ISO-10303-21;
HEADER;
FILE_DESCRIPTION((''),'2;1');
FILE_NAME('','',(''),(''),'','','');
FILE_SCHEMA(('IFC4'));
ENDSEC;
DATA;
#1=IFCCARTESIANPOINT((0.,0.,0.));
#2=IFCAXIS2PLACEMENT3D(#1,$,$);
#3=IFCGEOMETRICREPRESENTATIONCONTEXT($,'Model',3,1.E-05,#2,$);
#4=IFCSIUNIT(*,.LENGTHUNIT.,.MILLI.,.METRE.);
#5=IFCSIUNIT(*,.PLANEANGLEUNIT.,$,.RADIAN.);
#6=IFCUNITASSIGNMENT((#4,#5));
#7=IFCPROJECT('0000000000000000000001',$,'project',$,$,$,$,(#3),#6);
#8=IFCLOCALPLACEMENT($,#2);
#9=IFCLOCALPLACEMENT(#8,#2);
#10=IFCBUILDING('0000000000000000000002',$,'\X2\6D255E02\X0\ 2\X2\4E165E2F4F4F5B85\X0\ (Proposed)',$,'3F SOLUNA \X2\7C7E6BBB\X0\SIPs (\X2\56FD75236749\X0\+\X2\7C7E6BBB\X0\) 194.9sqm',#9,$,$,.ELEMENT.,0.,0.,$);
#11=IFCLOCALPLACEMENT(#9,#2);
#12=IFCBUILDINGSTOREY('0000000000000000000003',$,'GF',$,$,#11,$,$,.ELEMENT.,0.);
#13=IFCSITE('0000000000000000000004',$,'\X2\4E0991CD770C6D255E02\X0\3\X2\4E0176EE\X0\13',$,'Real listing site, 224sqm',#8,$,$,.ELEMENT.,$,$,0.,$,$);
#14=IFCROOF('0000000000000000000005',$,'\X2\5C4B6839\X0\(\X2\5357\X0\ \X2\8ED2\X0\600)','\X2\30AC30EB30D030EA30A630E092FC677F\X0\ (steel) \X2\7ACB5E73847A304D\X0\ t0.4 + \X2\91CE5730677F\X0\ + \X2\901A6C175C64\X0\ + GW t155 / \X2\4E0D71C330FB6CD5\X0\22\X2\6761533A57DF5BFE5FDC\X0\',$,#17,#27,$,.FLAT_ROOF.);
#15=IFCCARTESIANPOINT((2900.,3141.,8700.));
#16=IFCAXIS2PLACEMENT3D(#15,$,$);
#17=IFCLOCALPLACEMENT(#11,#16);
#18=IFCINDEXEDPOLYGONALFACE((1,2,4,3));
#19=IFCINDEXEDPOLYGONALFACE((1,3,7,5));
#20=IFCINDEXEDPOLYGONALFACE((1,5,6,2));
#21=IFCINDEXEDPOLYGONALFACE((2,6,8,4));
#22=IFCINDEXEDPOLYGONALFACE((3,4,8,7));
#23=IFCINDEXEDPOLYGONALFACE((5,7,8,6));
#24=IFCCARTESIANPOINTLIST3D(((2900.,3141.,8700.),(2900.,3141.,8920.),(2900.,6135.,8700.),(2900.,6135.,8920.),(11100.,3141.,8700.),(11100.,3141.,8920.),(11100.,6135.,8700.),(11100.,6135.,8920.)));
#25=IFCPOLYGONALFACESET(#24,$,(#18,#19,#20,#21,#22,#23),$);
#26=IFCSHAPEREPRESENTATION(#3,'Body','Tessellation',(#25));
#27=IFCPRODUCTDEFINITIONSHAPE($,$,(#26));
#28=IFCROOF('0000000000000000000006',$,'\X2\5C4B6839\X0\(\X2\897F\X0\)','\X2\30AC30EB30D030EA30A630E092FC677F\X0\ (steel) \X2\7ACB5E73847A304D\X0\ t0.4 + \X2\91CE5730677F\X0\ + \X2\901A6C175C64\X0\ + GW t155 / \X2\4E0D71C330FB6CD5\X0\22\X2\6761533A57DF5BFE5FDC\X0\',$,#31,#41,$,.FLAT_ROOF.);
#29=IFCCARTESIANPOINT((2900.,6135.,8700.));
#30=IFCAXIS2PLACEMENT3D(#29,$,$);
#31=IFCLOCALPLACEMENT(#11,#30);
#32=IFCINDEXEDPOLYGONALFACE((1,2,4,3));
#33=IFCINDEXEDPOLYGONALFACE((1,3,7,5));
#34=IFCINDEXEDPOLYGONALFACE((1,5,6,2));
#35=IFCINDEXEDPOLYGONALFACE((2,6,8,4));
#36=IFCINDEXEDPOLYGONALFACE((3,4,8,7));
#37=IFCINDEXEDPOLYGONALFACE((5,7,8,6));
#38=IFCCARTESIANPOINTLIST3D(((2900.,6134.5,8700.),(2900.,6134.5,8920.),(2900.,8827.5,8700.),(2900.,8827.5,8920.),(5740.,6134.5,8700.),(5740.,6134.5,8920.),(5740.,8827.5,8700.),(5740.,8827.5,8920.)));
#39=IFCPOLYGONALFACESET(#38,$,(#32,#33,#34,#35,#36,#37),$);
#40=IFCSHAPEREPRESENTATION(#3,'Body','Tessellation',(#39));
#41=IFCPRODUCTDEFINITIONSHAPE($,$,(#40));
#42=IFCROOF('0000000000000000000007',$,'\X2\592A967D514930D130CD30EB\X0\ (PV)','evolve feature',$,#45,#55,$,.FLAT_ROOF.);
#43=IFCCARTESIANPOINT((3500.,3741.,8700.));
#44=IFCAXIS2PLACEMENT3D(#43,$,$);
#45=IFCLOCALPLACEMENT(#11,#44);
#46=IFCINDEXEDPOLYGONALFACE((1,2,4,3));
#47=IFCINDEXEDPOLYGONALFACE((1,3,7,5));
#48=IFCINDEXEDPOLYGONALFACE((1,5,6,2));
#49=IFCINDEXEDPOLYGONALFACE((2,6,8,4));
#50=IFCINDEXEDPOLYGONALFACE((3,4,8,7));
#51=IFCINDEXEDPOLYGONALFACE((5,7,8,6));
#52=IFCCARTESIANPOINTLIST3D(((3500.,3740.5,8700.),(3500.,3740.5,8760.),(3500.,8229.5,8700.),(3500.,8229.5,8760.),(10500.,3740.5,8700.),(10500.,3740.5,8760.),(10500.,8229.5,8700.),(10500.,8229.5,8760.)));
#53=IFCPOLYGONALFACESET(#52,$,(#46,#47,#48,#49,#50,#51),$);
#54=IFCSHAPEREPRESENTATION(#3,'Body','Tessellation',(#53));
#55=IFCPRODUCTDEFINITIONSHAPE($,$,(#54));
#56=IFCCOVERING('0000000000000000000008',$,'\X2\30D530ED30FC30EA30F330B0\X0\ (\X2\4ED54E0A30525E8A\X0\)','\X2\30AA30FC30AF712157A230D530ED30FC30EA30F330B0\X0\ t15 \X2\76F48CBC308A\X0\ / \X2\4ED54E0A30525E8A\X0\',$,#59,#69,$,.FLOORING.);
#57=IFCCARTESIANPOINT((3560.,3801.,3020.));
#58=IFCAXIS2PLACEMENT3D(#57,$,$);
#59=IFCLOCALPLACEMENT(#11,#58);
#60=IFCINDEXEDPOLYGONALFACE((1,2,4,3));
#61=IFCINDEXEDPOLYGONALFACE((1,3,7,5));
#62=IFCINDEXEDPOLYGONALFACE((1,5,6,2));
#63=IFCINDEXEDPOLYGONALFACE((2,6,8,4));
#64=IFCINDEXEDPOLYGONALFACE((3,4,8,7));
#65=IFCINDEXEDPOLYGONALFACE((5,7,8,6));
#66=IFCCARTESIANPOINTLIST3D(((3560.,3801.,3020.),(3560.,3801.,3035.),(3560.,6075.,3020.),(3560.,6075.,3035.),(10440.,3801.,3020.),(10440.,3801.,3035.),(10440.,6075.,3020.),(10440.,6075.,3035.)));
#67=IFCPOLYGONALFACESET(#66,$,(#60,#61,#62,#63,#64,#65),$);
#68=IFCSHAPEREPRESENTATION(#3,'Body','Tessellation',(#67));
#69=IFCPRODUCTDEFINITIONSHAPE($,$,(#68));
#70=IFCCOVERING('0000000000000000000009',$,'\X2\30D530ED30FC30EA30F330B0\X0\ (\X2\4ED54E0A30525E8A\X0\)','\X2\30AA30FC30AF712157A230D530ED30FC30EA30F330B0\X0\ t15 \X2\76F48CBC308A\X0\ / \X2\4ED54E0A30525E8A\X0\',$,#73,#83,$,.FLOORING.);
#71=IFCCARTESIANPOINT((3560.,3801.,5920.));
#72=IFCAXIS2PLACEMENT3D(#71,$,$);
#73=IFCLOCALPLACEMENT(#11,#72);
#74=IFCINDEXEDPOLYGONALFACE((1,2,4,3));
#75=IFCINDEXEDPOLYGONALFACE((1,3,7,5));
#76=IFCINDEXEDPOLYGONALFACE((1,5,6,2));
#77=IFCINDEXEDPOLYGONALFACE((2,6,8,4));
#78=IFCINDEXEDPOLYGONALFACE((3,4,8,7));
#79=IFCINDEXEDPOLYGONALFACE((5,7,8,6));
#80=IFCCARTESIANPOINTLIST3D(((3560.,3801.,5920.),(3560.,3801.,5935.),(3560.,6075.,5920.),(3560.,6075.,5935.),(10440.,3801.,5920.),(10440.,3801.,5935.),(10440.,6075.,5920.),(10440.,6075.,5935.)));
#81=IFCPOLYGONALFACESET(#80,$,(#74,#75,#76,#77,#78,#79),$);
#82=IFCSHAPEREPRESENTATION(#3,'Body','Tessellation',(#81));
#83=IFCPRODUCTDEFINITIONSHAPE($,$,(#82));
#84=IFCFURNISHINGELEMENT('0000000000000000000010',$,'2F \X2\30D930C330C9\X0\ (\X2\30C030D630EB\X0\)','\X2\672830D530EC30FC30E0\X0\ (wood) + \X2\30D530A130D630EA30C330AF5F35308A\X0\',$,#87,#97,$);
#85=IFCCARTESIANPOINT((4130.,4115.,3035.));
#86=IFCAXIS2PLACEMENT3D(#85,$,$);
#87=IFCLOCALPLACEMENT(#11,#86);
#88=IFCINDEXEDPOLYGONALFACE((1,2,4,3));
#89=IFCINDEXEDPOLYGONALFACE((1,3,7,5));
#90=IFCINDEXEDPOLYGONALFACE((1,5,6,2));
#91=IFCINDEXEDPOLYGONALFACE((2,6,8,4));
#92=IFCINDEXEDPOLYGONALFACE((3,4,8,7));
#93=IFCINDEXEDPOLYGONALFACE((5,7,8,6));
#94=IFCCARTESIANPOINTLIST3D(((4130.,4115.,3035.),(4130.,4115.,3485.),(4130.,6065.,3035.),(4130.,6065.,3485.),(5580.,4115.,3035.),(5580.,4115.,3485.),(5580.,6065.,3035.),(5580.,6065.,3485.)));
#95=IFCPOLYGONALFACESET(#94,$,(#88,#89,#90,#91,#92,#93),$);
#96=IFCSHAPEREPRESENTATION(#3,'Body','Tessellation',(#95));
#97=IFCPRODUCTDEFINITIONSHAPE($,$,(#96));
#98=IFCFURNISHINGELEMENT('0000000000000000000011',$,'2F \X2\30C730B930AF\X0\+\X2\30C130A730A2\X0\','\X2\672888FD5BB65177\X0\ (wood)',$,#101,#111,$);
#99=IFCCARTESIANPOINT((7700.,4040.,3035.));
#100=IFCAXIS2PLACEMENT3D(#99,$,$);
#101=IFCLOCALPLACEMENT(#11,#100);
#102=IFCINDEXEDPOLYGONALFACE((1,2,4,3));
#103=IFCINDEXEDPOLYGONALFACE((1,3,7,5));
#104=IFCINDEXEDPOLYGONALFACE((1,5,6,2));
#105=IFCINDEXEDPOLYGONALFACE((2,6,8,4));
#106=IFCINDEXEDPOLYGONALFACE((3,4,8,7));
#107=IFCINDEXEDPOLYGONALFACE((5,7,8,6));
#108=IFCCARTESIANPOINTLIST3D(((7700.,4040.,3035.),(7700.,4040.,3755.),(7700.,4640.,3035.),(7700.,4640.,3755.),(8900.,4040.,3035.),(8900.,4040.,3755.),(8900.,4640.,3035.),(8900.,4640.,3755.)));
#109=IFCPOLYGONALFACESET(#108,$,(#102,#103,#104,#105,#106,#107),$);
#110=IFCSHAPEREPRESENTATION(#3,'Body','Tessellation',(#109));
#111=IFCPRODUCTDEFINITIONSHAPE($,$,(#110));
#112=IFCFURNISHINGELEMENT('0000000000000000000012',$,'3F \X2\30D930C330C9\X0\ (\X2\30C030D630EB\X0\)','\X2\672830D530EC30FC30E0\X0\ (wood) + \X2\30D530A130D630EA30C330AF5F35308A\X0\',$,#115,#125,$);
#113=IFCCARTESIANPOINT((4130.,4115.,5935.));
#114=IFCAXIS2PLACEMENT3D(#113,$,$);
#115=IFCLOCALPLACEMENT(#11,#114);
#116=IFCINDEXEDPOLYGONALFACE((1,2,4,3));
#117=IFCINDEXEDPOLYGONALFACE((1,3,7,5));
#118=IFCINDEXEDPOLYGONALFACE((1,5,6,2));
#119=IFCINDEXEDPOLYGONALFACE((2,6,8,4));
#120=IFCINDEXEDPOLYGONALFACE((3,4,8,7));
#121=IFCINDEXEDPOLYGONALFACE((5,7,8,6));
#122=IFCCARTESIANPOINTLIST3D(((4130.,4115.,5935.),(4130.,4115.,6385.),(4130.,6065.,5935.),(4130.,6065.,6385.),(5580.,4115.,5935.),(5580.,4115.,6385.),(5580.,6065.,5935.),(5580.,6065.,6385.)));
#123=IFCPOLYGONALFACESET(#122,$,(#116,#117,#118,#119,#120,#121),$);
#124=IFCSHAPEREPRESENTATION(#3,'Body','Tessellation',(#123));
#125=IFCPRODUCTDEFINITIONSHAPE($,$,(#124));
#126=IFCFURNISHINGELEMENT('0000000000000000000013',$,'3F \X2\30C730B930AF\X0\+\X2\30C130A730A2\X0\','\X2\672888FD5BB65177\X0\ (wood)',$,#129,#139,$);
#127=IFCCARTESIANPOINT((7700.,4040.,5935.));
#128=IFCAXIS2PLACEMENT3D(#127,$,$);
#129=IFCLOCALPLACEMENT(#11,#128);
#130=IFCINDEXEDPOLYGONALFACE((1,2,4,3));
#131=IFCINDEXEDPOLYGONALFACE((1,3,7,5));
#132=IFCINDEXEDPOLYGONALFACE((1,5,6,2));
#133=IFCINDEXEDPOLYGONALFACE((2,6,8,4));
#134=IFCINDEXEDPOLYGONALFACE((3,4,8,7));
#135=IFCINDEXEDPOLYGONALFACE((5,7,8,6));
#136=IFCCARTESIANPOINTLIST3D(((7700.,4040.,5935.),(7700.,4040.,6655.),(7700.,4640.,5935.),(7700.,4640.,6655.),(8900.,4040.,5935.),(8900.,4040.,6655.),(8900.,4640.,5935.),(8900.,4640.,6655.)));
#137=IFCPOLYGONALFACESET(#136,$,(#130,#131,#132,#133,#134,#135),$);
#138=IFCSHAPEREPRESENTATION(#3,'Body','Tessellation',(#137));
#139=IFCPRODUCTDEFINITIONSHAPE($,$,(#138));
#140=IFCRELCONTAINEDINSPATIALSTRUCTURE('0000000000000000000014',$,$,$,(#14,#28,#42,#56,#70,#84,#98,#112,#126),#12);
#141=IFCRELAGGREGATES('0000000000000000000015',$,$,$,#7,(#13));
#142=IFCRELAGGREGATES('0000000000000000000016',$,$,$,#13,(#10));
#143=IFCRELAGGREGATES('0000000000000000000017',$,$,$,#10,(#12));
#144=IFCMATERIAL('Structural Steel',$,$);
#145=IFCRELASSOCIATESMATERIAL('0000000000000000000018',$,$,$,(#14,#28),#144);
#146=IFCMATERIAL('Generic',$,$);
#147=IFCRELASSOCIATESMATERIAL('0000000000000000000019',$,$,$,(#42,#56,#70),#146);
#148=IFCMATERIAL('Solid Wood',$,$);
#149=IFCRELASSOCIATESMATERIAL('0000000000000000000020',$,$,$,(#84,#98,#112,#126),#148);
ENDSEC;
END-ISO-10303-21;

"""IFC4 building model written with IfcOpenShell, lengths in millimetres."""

from ifc_helpers import new_model, si_unit, frame, frame_2d, origin, place, context, project, spatial, rectangle, extrude, material, element, save


model = new_model("IFC4")

# Units and contexts
model_context = context("Model", 3, precision=1e-05, world=origin())
ifc_project = project(units=[si_unit("LENGTHUNIT", "METRE", prefix="MILLI"), si_unit("PLANEANGLEUNIT", "RADIAN")], contexts=[model_context])

# Site, building, storey
site_placement = place(None, origin())
site = spatial("IfcSite", under=ifc_project, at=site_placement, Name="三重県津市3丁目13", ObjectType="Real listing site, 224sqm", CompositionType="ELEMENT", RefElevation=0.0)
building_placement = place(site_placement, origin())
building = spatial("IfcBuilding", under=site, at=building_placement, Name="津市 2世帯住宅 (Proposed)", ObjectType="3F SOLUNA 籾殻SIPs (国産杉+籾殻) 194.9sqm", CompositionType="ELEMENT", ElevationOfRefHeight=0.0, ElevationOfTerrain=0.0)
storey_placement = place(building_placement, origin())
storey = spatial("IfcBuildingStorey", under=building, at=storey_placement, Name="GF", CompositionType="ELEMENT", Elevation=0.0)

# Shared definitions
ifc_material_1 = material(Name="Solid Wood")

# Roofs
ifc_material_2 = material(Name="Structural Steel")
roof_1_placement = place(storey_placement, frame((2900.0, 3141.0, 8700.0)))
element("IfcRoof", 1, at=roof_1_placement, inside=storey, material=ifc_material_2, Name="屋根(南 軒600)", Description="ガルバリウム鋼板 (steel) 立平葺き t0.4 + 野地板 + 通気層 + GW t155 / 不燃・法22条区域対応", PredefinedType="FLAT_ROOF", context=model_context, shape_type="SweptSolid", body=[
    extrude(rectangle(XDim=8200.0, YDim=2994.0, at=frame_2d((4100.0, 1497.0))), frame((2900.0, 3141.0, 8700.0)), (0.0, 0.0, 1.0), 220.0),
])
roof_2_placement = place(storey_placement, frame((2900.0, 6135.0, 8700.0)))
element("IfcRoof", 2, at=roof_2_placement, inside=storey, material=ifc_material_2, Name="屋根(西)", Description="ガルバリウム鋼板 (steel) 立平葺き t0.4 + 野地板 + 通気層 + GW t155 / 不燃・法22条区域対応", PredefinedType="FLAT_ROOF", context=model_context, shape_type="SweptSolid", body=[
    extrude(rectangle(XDim=2840.0, YDim=2693.0, at=frame_2d((1420.0, 1346.0))), frame((2900.0, 6135.0, 8700.0)), (0.0, 0.0, 1.0), 220.0),
])
ifc_material_3 = material(Name="Generic")
roof_3_placement = place(storey_placement, frame((3500.0, 3741.0, 8700.0)))
element("IfcRoof", 3, at=roof_3_placement, inside=storey, material=ifc_material_3, Name="太陽光パネル (PV)", Description="evolve feature", PredefinedType="FLAT_ROOF", context=model_context, shape_type="SweptSolid", body=[
    extrude(rectangle(XDim=7000.0, YDim=4489.0, at=frame_2d((3500.0, 2244.0))), frame((3500.0, 3741.0, 8700.0)), (0.0, 0.0, 1.0), 60.0),
])

# Coverings
covering_1_placement = place(storey_placement, frame((3560.0, 3801.0, 3020.0)))
element("IfcCovering", 4, at=covering_1_placement, inside=storey, material=ifc_material_3, Name="フローリング (仕上げ床)", Description="オーク無垢フローリング t15 直貼り / 仕上げ床", PredefinedType="FLOORING", context=model_context, shape_type="SweptSolid", body=[
    extrude(rectangle(XDim=6880.0, YDim=2274.0, at=frame_2d((3440.0, 1137.0))), frame((3560.0, 3801.0, 3020.0)), (0.0, 0.0, 1.0), 15.0),
])
covering_2_placement = place(storey_placement, frame((3560.0, 3801.0, 5920.0)))
element("IfcCovering", 5, at=covering_2_placement, inside=storey, material=ifc_material_3, Name="フローリング (仕上げ床)", Description="オーク無垢フローリング t15 直貼り / 仕上げ床", PredefinedType="FLOORING", context=model_context, shape_type="SweptSolid", body=[
    extrude(rectangle(XDim=6880.0, YDim=2274.0, at=frame_2d((3440.0, 1137.0))), frame((3560.0, 3801.0, 5920.0)), (0.0, 0.0, 1.0), 15.0),
])

# Furnishing elements
furnishing_1_placement = place(storey_placement, frame((4130.0, 4115.0, 3035.0)))
element("IfcFurnishingElement", 6, at=furnishing_1_placement, inside=storey, material=ifc_material_1, Name="2F ベッド (ダブル)", Description="木フレーム (wood) + ファブリック張り", context=model_context, shape_type="SweptSolid", body=[
    extrude(rectangle(XDim=1450.0, YDim=1950.0, at=frame_2d((725.0, 975.0))), frame((4130.0, 4115.0, 3035.0)), (0.0, 0.0, 1.0), 450.0),
])
furnishing_2_placement = place(storey_placement, frame((7700.0, 4040.0, 3035.0)))
element("IfcFurnishingElement", 7, at=furnishing_2_placement, inside=storey, material=ifc_material_1, Name="2F デスク+チェア", Description="木製家具 (wood)", context=model_context, shape_type="SweptSolid", body=[
    extrude(rectangle(XDim=1200.0, YDim=600.0, at=frame_2d((600.0, 300.0))), frame((7700.0, 4040.0, 3035.0)), (0.0, 0.0, 1.0), 720.0),
])
furnishing_3_placement = place(storey_placement, frame((4130.0, 4115.0, 5935.0)))
element("IfcFurnishingElement", 8, at=furnishing_3_placement, inside=storey, material=ifc_material_1, Name="3F ベッド (ダブル)", Description="木フレーム (wood) + ファブリック張り", context=model_context, shape_type="SweptSolid", body=[
    extrude(rectangle(XDim=1450.0, YDim=1950.0, at=frame_2d((725.0, 975.0))), frame((4130.0, 4115.0, 5935.0)), (0.0, 0.0, 1.0), 450.0),
])
furnishing_4_placement = place(storey_placement, frame((7700.0, 4040.0, 5935.0)))
element("IfcFurnishingElement", 9, at=furnishing_4_placement, inside=storey, material=ifc_material_1, Name="3F デスク+チェア", Description="木製家具 (wood)", context=model_context, shape_type="SweptSolid", body=[
    extrude(rectangle(XDim=1200.0, YDim=600.0, at=frame_2d((600.0, 300.0))), frame((7700.0, 4040.0, 5935.0)), (0.0, 0.0, 1.0), 720.0),
])

save(model, "model.ifc")
